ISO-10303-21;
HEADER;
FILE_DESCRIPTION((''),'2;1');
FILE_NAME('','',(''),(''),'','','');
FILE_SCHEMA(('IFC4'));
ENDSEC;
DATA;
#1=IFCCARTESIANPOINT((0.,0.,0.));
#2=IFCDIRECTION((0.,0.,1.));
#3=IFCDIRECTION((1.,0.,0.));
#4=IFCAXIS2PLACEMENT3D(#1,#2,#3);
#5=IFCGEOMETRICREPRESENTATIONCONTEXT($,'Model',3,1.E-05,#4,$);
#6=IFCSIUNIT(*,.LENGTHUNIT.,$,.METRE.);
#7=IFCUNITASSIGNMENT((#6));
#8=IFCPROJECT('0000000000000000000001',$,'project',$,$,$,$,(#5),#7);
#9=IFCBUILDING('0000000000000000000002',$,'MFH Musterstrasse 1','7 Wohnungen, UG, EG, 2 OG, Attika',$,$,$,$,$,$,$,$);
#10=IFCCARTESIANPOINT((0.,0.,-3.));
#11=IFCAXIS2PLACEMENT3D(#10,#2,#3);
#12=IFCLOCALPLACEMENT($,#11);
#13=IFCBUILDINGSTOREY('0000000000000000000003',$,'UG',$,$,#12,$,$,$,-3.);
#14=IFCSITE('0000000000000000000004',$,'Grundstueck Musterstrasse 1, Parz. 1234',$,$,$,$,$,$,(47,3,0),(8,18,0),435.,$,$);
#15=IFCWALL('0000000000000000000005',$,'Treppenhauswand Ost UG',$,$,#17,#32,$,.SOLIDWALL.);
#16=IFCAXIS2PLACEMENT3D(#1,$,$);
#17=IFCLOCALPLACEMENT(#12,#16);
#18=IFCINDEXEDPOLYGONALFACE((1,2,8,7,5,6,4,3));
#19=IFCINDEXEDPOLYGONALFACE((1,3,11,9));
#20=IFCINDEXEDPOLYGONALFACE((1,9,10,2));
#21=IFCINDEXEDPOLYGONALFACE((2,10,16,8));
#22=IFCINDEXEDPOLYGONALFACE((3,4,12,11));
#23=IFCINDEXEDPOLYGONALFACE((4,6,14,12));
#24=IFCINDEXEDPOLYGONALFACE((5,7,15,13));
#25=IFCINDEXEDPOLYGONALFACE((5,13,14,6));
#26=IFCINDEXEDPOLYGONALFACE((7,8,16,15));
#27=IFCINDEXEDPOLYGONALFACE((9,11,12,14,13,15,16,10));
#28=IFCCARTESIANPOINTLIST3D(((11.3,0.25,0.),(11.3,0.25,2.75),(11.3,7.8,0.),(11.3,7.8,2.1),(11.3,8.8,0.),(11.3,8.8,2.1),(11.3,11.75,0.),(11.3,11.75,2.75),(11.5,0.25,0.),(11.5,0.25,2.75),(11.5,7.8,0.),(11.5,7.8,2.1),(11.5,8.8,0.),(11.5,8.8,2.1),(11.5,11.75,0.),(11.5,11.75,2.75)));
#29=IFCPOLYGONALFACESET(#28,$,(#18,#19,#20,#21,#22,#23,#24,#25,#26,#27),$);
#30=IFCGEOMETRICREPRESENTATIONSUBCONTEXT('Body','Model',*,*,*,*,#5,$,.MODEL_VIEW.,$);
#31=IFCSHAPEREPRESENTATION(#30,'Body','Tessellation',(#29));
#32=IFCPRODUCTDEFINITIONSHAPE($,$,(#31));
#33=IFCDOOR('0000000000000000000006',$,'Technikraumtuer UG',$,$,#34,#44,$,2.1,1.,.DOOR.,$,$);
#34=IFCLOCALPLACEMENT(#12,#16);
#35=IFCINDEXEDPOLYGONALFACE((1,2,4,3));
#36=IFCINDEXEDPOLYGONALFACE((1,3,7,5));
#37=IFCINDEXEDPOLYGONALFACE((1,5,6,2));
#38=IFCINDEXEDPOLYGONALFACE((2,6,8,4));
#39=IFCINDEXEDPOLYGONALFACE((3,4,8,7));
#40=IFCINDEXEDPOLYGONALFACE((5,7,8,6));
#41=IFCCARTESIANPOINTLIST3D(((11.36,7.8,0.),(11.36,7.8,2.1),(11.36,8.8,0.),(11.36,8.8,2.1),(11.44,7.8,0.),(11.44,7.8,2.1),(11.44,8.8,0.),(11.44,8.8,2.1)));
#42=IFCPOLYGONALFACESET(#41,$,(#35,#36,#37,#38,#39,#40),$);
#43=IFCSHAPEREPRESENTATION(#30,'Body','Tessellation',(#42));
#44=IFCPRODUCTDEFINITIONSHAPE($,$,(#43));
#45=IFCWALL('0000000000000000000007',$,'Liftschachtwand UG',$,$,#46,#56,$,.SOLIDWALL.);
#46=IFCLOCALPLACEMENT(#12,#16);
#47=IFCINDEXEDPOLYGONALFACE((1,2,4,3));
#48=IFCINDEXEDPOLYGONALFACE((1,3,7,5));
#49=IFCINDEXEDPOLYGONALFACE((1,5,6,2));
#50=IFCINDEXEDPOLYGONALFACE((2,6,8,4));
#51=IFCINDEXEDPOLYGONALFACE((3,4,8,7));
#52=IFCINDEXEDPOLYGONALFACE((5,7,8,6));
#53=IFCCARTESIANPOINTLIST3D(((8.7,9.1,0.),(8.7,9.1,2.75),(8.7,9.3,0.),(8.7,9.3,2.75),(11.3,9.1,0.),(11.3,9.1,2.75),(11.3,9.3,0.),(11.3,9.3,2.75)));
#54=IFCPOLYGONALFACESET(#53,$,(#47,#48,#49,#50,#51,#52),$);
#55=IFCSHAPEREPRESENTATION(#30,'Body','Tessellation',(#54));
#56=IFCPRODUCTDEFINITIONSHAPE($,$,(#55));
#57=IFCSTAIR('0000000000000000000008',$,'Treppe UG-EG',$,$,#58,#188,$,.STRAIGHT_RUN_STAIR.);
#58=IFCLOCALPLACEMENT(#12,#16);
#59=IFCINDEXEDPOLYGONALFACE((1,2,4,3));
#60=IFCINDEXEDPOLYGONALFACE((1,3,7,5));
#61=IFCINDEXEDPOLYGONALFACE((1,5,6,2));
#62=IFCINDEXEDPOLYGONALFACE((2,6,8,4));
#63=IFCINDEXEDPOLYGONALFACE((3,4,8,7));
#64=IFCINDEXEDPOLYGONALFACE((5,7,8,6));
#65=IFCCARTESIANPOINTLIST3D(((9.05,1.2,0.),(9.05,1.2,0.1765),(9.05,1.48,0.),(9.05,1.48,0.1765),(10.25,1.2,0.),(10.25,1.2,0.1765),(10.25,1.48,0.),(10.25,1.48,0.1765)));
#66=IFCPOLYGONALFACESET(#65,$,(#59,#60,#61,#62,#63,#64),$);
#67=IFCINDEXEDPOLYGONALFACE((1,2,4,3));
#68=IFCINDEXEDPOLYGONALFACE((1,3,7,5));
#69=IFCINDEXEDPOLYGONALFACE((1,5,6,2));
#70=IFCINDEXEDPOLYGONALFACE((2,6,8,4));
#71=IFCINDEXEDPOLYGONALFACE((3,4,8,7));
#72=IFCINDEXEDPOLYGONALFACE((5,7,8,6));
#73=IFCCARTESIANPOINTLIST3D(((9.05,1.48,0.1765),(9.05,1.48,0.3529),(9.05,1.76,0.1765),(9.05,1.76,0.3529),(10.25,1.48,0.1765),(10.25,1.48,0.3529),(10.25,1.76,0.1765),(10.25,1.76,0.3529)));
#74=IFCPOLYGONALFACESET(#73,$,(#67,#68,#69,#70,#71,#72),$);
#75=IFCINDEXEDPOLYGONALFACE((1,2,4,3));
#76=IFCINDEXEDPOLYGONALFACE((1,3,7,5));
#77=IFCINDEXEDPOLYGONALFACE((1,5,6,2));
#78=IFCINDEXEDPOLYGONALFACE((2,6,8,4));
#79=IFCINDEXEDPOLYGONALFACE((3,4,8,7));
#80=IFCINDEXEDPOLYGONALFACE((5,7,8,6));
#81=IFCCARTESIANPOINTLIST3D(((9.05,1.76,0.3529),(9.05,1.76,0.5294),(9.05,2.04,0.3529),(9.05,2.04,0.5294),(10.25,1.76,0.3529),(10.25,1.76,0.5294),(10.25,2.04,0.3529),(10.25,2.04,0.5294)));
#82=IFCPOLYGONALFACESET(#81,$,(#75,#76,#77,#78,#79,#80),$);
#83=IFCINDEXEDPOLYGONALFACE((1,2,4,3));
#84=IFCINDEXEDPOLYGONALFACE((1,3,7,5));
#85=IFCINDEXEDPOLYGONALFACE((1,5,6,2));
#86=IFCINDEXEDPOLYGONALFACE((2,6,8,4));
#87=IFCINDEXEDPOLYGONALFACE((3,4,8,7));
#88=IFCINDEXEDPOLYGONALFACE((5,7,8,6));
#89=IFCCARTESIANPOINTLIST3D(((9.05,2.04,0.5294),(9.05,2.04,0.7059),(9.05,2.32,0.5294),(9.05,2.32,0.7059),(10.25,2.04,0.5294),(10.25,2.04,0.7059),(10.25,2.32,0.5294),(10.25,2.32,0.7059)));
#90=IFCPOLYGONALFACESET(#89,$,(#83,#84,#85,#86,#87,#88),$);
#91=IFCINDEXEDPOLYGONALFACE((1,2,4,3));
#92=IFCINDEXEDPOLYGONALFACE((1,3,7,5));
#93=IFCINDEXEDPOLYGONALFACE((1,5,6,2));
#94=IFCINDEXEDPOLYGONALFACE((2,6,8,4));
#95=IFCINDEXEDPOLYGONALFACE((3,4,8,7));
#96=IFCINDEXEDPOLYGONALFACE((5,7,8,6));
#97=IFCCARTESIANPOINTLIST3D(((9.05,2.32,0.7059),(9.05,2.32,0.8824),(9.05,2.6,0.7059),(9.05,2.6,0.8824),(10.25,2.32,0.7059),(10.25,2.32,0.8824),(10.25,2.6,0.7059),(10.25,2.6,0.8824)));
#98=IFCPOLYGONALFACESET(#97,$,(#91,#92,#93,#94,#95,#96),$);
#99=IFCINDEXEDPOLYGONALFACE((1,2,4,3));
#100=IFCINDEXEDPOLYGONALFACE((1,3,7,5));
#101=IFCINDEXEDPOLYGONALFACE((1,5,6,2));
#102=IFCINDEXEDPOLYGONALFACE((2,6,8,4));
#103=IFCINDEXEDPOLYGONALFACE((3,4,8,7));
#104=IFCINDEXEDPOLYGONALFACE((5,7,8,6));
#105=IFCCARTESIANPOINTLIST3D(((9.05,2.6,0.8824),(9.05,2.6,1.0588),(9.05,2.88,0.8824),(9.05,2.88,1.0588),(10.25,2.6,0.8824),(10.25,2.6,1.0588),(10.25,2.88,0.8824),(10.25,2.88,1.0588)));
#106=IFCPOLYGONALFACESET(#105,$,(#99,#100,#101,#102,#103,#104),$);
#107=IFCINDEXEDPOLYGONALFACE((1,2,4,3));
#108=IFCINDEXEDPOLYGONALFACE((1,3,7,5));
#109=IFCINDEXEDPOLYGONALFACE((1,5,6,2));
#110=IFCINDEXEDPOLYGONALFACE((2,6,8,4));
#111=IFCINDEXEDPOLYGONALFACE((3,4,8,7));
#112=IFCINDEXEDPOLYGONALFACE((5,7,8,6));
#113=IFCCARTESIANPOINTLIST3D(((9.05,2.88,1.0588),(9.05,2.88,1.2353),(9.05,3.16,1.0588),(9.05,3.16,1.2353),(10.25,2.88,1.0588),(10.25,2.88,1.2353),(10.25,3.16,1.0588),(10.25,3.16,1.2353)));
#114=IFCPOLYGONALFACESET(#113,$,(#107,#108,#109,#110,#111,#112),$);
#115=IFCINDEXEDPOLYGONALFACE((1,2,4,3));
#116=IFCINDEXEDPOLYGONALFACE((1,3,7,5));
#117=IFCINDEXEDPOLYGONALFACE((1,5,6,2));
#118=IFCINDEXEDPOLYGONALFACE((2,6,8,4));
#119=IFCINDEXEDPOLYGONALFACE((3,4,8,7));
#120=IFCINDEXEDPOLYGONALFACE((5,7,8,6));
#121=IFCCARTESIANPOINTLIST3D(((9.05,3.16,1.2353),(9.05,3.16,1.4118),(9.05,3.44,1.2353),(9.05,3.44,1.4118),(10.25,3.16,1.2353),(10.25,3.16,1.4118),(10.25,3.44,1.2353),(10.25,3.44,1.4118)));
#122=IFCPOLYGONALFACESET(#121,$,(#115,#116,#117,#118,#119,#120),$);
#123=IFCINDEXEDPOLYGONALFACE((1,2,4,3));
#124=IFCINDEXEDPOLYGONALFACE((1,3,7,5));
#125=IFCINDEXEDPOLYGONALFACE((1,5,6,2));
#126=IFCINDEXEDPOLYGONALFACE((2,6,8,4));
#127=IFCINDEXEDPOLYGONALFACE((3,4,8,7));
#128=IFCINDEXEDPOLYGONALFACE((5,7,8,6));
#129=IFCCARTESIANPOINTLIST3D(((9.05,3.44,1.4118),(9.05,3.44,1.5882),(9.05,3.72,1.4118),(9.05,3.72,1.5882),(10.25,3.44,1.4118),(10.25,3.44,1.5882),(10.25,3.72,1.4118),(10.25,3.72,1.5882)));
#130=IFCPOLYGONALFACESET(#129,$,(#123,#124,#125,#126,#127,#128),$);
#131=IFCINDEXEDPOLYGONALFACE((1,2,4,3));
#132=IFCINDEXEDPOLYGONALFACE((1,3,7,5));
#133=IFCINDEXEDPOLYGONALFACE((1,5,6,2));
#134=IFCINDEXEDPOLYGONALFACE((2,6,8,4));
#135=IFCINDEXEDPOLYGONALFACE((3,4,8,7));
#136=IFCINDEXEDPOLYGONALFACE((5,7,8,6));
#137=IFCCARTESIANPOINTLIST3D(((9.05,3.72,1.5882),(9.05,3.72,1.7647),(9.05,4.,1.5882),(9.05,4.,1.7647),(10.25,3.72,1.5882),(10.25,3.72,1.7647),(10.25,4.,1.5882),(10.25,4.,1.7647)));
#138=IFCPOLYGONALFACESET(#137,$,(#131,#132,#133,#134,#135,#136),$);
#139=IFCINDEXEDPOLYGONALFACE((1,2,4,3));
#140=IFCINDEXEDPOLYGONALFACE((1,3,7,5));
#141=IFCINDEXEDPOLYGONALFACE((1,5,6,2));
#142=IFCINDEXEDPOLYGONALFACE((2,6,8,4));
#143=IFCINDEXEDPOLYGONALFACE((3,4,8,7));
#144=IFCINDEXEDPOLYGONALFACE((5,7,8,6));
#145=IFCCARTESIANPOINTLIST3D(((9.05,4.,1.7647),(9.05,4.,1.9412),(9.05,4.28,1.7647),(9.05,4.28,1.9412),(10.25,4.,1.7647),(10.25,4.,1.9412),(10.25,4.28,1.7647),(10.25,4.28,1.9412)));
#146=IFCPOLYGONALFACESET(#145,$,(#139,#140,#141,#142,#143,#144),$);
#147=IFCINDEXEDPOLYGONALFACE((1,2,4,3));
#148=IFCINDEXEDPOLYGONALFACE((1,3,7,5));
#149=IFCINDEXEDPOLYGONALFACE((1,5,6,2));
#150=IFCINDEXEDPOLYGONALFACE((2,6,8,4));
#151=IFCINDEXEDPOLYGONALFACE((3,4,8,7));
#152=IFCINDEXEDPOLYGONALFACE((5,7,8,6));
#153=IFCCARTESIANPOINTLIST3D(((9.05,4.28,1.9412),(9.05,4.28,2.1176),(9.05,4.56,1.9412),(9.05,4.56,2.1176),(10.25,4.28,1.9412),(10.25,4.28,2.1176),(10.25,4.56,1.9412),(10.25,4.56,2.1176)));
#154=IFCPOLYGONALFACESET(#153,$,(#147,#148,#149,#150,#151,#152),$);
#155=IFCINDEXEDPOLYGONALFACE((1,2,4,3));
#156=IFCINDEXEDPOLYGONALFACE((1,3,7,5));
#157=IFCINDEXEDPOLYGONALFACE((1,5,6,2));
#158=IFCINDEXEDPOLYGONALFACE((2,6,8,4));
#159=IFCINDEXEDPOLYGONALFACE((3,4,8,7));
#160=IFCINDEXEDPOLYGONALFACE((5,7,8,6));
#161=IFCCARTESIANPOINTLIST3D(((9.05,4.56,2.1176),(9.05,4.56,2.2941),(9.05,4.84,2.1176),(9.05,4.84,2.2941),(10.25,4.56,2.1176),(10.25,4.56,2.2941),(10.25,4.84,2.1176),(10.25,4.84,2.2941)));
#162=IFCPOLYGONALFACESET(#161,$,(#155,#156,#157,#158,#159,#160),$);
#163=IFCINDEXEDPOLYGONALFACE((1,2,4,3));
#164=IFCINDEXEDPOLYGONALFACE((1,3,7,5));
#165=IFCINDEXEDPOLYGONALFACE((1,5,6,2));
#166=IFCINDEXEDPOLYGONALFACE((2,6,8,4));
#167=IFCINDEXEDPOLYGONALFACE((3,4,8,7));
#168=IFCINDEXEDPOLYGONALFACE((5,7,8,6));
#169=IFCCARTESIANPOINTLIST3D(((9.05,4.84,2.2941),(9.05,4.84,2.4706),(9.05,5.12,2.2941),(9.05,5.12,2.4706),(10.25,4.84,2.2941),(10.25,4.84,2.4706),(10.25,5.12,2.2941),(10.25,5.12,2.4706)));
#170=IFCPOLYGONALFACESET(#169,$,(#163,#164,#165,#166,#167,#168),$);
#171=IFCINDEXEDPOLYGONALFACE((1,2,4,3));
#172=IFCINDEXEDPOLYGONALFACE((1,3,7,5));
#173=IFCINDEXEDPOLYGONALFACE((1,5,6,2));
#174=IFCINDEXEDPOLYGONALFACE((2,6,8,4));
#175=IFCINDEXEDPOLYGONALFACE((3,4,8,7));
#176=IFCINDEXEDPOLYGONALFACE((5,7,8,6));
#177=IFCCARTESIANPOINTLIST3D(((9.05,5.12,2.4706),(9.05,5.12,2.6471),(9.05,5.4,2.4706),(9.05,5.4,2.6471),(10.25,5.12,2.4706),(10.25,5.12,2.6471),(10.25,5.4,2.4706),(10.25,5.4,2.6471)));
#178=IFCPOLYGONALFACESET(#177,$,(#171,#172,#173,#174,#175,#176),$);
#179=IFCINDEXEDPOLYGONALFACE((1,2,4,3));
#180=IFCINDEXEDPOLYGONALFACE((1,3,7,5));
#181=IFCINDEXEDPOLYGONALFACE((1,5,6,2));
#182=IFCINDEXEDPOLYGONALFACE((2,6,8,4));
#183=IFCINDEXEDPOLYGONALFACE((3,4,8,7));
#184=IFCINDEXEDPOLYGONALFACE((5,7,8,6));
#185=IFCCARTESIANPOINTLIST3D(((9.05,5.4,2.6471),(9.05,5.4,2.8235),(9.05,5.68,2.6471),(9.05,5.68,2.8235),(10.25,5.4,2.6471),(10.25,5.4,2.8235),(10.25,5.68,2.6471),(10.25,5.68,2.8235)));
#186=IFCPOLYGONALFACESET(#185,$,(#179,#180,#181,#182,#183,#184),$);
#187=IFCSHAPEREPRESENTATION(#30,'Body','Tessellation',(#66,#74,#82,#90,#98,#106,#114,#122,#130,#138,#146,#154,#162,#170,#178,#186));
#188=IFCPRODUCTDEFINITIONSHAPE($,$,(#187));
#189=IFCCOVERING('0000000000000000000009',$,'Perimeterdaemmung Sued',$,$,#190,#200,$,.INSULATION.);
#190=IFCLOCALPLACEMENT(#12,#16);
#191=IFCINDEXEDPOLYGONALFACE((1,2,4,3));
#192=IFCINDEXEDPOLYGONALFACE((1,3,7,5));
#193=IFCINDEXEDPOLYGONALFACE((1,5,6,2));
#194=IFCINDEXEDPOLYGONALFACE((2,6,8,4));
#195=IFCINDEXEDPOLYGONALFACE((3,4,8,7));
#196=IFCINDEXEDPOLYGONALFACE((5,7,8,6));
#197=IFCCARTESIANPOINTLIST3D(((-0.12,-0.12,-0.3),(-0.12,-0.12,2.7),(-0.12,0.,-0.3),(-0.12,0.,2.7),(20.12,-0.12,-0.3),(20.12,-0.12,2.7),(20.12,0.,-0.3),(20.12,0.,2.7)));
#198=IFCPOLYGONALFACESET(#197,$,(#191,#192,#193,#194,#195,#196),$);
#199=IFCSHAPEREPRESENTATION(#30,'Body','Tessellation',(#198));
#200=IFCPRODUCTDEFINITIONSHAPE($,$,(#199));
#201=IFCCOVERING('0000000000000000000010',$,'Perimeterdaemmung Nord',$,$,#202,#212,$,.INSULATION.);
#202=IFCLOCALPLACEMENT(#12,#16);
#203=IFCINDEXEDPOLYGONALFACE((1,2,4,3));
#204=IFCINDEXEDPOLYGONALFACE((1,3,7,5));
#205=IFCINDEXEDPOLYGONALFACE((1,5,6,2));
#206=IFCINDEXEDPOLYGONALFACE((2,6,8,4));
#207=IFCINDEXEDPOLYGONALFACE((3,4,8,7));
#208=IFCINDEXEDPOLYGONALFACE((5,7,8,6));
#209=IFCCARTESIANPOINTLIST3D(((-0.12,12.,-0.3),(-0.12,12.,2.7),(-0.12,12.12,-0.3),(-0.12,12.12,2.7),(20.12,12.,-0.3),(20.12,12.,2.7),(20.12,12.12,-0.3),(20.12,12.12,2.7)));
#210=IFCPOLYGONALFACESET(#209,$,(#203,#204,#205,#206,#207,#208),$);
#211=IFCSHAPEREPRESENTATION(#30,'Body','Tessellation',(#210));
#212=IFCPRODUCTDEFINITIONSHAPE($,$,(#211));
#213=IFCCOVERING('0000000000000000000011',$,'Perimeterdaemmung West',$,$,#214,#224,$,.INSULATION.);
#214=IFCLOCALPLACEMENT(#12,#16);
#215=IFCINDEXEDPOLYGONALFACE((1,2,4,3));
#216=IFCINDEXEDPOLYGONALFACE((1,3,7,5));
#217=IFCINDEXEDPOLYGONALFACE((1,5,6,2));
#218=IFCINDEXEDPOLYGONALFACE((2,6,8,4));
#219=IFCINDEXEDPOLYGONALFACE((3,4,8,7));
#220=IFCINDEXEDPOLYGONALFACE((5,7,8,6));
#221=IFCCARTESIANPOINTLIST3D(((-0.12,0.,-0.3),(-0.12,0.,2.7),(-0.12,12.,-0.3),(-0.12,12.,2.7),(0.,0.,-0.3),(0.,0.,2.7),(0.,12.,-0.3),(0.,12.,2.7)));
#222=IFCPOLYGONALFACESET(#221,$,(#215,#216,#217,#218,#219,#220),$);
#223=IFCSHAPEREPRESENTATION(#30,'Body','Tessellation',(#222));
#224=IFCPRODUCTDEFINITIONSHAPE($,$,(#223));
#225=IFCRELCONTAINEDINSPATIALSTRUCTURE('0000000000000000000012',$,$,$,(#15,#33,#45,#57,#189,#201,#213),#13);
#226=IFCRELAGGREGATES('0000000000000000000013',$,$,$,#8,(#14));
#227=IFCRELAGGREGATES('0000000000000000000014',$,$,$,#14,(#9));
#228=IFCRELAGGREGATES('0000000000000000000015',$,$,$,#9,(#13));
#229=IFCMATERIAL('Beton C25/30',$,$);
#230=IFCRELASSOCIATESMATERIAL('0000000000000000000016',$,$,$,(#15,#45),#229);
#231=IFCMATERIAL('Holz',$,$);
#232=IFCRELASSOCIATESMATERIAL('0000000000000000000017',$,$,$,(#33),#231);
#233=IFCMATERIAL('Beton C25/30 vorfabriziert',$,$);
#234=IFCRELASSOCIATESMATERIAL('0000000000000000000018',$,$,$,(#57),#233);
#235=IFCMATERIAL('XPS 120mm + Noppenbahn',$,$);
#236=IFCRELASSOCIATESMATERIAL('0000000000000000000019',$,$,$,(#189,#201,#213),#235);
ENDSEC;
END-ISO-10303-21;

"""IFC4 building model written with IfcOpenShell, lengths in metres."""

from ifc_helpers import new_model, si_unit, frame, frame_2d, origin_with_axes, place, context, subcontext, project, spatial, rectangle, extrude, material, element, fill, save


model = new_model("IFC4")

# Units and contexts
model_context = context("Model", 3, precision=1e-05, world=origin_with_axes())
body_context = subcontext(model_context, "Body", "Model", "MODEL_VIEW")
ifc_project = project(units=[si_unit("LENGTHUNIT", "METRE")], contexts=[model_context])

# Site, building, storey
site = spatial("IfcSite", under=ifc_project, Name="Grundstueck Musterstrasse 1, Parz. 1234", RefLatitude=(47, 3, 0), RefLongitude=(8, 18, 0), RefElevation=435.0)
building = spatial("IfcBuilding", under=site, Name="MFH Musterstrasse 1", Description="7 Wohnungen, UG, EG, 2 OG, Attika")
storey_placement = place(None, frame((0.0, 0.0, -3.0), z_axis=(0.0, 0.0, 1.0), x_axis=(1.0, 0.0, 0.0)))
storey = spatial("IfcBuildingStorey", under=building, at=storey_placement, Name="UG", Elevation=-3.0)

# Shared definitions
ifc_material_1 = material(Name="Beton C25/30")

# Wall, opening, door
ifc_material_2 = material(Name="Holz")
wall_1_placement = place(storey_placement, frame((11.3, 0.25, 0.0), z_axis=(0.0, 0.0, 1.0), x_axis=(1.0, 0.0, 0.0)))
wall_1 = element("IfcWall", 1, at=wall_1_placement, inside=storey, material=ifc_material_1, Name="Treppenhauswand Ost UG", PredefinedType="SOLIDWALL", context=body_context, shape_type="SweptSolid", body=[
    extrude(rectangle(XDim=0.2, YDim=11.5, at=frame_2d((0.1, 5.75))), origin_with_axes(), (0.0, 0.0, 1.0), 2.75),
])
opening_1_placement = place(wall_1_placement, frame((-0.01, 7.55, 0.0), z_axis=(0.0, 0.0, 1.0), x_axis=(1.0, 0.0, 0.0)))
opening_1 = element("IfcOpeningElement", 2, at=opening_1_placement, cuts=wall_1, context=body_context, shape_type="SweptSolid", body=[
    extrude(rectangle(XDim=0.22, YDim=1.0, at=frame_2d((0.11, 0.5))), origin_with_axes(), (0.0, 0.0, 1.0), 2.1),
])
door_1_placement = place(storey_placement, frame((11.36, 7.8, 0.0), z_axis=(0.0, 0.0, 1.0), x_axis=(1.0, 0.0, 0.0)))
door_1 = element("IfcDoor", 3, at=door_1_placement, inside=storey, material=ifc_material_2, Name="Technikraumtuer UG", OverallHeight=2.1, OverallWidth=1.0, PredefinedType="DOOR", context=body_context, shape_type="SweptSolid", body=[
    extrude(rectangle(XDim=0.08, YDim=1.0, at=frame_2d((0.04, 0.5))), origin_with_axes(), (0.0, 0.0, 1.0), 2.1),
])
fill(opening_1, door_1)

# Wall
wall_2_placement = place(storey_placement, frame((8.7, 9.1, 0.0), z_axis=(0.0, 0.0, 1.0), x_axis=(1.0, 0.0, 0.0)))
element("IfcWall", 4, at=wall_2_placement, inside=storey, material=ifc_material_1, Name="Liftschachtwand UG", PredefinedType="SOLIDWALL", context=body_context, shape_type="SweptSolid", body=[
    extrude(rectangle(XDim=2.6, YDim=0.2, at=frame_2d((1.3, 0.1))), origin_with_axes(), (0.0, 0.0, 1.0), 2.75),
])

# Stair
ifc_material_3 = material(Name="Beton C25/30 vorfabriziert")
stair_placement = place(storey_placement, origin_with_axes())
element("IfcStair", 5, at=stair_placement, inside=storey, material=ifc_material_3, Name="Treppe UG-EG", PredefinedType="STRAIGHT_RUN_STAIR", context=body_context, shape_type="SweptSolid", body=[
    extrude(rectangle(XDim=1.2, YDim=0.28, at=frame_2d((0.6, 0.14))), frame((9.05, 1.2, 0.0)), (0.0, 0.0, 1.0), 0.1765),
    extrude(rectangle(XDim=1.2, YDim=0.28, at=frame_2d((0.6, 0.14))), frame((9.05, 1.48, 0.1765)), (0.0, 0.0, 1.0), 0.1765),
    extrude(rectangle(XDim=1.2, YDim=0.28, at=frame_2d((0.6, 0.14))), frame((9.05, 1.76, 0.3529)), (0.0, 0.0, 1.0), 0.1765),
    extrude(rectangle(XDim=1.2, YDim=0.28, at=frame_2d((0.6, 0.14))), frame((9.05, 2.04, 0.5294)), (0.0, 0.0, 1.0), 0.1765),
    extrude(rectangle(XDim=1.2, YDim=0.28, at=frame_2d((0.6, 0.14))), frame((9.05, 2.32, 0.7059)), (0.0, 0.0, 1.0), 0.1765),
    extrude(rectangle(XDim=1.2, YDim=0.28, at=frame_2d((0.6, 0.14))), frame((9.05, 2.6, 0.8824)), (0.0, 0.0, 1.0), 0.1765),
    extrude(rectangle(XDim=1.2, YDim=0.28, at=frame_2d((0.6, 0.14))), frame((9.05, 2.88, 1.0588)), (0.0, 0.0, 1.0), 0.1765),
    extrude(rectangle(XDim=1.2, YDim=0.28, at=frame_2d((0.6, 0.14))), frame((9.05, 3.16, 1.2353)), (0.0, 0.0, 1.0), 0.1765),
    extrude(rectangle(XDim=1.2, YDim=0.28, at=frame_2d((0.6, 0.14))), frame((9.05, 3.44, 1.4118)), (0.0, 0.0, 1.0), 0.1765),
    extrude(rectangle(XDim=1.2, YDim=0.28, at=frame_2d((0.6, 0.14))), frame((9.05, 3.72, 1.5882)), (0.0, 0.0, 1.0), 0.1765),
    extrude(rectangle(XDim=1.2, YDim=0.28, at=frame_2d((0.6, 0.14))), frame((9.05, 4.0, 1.7647)), (0.0, 0.0, 1.0), 0.1765),
    extrude(rectangle(XDim=1.2, YDim=0.28, at=frame_2d((0.6, 0.14))), frame((9.05, 4.28, 1.9412)), (0.0, 0.0, 1.0), 0.1765),
    extrude(rectangle(XDim=1.2, YDim=0.28, at=frame_2d((0.6, 0.14))), frame((9.05, 4.56, 2.1176)), (0.0, 0.0, 1.0), 0.1765),
    extrude(rectangle(XDim=1.2, YDim=0.28, at=frame_2d((0.6, 0.14))), frame((9.05, 4.84, 2.2941)), (0.0, 0.0, 1.0), 0.1765),
    extrude(rectangle(XDim=1.2, YDim=0.28, at=frame_2d((0.6, 0.14))), frame((9.05, 5.12, 2.4706)), (0.0, 0.0, 1.0), 0.1765),
    extrude(rectangle(XDim=1.2, YDim=0.28, at=frame_2d((0.6, 0.14))), frame((9.05, 5.4, 2.6471)), (0.0, 0.0, 1.0), 0.1765),
])

# Coverings
ifc_material_4 = material(Name="XPS 120mm + Noppenbahn")
for number, where, z_axis, x_axis, name in (
    (6, (-0.12, -0.12, -0.3), (0.0, 0.0, 1.0), (1.0, 0.0, 0.0), "Perimeterdaemmung Sued"),
    (7, (-0.12, 12.0, -0.3), (0.0, 0.0, 1.0), (1.0, 0.0, 0.0), "Perimeterdaemmung Nord"),
):
    element("IfcCovering", number, at=place(storey_placement, frame(where, z_axis=z_axis, x_axis=x_axis)), inside=storey, material=ifc_material_4, Name=name, PredefinedType="INSULATION", context=body_context, shape_type="SweptSolid", body=[
        extrude(rectangle(XDim=20.24, YDim=0.12, at=frame_2d((10.12, 0.06))), origin_with_axes(), (0.0, 0.0, 1.0), 3.0),
    ])
for number, where, z_axis, x_axis, name in (
    (8, (-0.12, 0.0, -0.3), (0.0, 0.0, 1.0), (1.0, 0.0, 0.0), "Perimeterdaemmung West"),
):
    element("IfcCovering", number, at=place(storey_placement, frame(where, z_axis=z_axis, x_axis=x_axis)), inside=storey, material=ifc_material_4, Name=name, PredefinedType="INSULATION", context=body_context, shape_type="SweptSolid", body=[
        extrude(rectangle(XDim=0.12, YDim=12.0, at=frame_2d((0.06, 6.0))), origin_with_axes(), (0.0, 0.0, 1.0), 3.0),
    ])

save(model, "model.ifc")
